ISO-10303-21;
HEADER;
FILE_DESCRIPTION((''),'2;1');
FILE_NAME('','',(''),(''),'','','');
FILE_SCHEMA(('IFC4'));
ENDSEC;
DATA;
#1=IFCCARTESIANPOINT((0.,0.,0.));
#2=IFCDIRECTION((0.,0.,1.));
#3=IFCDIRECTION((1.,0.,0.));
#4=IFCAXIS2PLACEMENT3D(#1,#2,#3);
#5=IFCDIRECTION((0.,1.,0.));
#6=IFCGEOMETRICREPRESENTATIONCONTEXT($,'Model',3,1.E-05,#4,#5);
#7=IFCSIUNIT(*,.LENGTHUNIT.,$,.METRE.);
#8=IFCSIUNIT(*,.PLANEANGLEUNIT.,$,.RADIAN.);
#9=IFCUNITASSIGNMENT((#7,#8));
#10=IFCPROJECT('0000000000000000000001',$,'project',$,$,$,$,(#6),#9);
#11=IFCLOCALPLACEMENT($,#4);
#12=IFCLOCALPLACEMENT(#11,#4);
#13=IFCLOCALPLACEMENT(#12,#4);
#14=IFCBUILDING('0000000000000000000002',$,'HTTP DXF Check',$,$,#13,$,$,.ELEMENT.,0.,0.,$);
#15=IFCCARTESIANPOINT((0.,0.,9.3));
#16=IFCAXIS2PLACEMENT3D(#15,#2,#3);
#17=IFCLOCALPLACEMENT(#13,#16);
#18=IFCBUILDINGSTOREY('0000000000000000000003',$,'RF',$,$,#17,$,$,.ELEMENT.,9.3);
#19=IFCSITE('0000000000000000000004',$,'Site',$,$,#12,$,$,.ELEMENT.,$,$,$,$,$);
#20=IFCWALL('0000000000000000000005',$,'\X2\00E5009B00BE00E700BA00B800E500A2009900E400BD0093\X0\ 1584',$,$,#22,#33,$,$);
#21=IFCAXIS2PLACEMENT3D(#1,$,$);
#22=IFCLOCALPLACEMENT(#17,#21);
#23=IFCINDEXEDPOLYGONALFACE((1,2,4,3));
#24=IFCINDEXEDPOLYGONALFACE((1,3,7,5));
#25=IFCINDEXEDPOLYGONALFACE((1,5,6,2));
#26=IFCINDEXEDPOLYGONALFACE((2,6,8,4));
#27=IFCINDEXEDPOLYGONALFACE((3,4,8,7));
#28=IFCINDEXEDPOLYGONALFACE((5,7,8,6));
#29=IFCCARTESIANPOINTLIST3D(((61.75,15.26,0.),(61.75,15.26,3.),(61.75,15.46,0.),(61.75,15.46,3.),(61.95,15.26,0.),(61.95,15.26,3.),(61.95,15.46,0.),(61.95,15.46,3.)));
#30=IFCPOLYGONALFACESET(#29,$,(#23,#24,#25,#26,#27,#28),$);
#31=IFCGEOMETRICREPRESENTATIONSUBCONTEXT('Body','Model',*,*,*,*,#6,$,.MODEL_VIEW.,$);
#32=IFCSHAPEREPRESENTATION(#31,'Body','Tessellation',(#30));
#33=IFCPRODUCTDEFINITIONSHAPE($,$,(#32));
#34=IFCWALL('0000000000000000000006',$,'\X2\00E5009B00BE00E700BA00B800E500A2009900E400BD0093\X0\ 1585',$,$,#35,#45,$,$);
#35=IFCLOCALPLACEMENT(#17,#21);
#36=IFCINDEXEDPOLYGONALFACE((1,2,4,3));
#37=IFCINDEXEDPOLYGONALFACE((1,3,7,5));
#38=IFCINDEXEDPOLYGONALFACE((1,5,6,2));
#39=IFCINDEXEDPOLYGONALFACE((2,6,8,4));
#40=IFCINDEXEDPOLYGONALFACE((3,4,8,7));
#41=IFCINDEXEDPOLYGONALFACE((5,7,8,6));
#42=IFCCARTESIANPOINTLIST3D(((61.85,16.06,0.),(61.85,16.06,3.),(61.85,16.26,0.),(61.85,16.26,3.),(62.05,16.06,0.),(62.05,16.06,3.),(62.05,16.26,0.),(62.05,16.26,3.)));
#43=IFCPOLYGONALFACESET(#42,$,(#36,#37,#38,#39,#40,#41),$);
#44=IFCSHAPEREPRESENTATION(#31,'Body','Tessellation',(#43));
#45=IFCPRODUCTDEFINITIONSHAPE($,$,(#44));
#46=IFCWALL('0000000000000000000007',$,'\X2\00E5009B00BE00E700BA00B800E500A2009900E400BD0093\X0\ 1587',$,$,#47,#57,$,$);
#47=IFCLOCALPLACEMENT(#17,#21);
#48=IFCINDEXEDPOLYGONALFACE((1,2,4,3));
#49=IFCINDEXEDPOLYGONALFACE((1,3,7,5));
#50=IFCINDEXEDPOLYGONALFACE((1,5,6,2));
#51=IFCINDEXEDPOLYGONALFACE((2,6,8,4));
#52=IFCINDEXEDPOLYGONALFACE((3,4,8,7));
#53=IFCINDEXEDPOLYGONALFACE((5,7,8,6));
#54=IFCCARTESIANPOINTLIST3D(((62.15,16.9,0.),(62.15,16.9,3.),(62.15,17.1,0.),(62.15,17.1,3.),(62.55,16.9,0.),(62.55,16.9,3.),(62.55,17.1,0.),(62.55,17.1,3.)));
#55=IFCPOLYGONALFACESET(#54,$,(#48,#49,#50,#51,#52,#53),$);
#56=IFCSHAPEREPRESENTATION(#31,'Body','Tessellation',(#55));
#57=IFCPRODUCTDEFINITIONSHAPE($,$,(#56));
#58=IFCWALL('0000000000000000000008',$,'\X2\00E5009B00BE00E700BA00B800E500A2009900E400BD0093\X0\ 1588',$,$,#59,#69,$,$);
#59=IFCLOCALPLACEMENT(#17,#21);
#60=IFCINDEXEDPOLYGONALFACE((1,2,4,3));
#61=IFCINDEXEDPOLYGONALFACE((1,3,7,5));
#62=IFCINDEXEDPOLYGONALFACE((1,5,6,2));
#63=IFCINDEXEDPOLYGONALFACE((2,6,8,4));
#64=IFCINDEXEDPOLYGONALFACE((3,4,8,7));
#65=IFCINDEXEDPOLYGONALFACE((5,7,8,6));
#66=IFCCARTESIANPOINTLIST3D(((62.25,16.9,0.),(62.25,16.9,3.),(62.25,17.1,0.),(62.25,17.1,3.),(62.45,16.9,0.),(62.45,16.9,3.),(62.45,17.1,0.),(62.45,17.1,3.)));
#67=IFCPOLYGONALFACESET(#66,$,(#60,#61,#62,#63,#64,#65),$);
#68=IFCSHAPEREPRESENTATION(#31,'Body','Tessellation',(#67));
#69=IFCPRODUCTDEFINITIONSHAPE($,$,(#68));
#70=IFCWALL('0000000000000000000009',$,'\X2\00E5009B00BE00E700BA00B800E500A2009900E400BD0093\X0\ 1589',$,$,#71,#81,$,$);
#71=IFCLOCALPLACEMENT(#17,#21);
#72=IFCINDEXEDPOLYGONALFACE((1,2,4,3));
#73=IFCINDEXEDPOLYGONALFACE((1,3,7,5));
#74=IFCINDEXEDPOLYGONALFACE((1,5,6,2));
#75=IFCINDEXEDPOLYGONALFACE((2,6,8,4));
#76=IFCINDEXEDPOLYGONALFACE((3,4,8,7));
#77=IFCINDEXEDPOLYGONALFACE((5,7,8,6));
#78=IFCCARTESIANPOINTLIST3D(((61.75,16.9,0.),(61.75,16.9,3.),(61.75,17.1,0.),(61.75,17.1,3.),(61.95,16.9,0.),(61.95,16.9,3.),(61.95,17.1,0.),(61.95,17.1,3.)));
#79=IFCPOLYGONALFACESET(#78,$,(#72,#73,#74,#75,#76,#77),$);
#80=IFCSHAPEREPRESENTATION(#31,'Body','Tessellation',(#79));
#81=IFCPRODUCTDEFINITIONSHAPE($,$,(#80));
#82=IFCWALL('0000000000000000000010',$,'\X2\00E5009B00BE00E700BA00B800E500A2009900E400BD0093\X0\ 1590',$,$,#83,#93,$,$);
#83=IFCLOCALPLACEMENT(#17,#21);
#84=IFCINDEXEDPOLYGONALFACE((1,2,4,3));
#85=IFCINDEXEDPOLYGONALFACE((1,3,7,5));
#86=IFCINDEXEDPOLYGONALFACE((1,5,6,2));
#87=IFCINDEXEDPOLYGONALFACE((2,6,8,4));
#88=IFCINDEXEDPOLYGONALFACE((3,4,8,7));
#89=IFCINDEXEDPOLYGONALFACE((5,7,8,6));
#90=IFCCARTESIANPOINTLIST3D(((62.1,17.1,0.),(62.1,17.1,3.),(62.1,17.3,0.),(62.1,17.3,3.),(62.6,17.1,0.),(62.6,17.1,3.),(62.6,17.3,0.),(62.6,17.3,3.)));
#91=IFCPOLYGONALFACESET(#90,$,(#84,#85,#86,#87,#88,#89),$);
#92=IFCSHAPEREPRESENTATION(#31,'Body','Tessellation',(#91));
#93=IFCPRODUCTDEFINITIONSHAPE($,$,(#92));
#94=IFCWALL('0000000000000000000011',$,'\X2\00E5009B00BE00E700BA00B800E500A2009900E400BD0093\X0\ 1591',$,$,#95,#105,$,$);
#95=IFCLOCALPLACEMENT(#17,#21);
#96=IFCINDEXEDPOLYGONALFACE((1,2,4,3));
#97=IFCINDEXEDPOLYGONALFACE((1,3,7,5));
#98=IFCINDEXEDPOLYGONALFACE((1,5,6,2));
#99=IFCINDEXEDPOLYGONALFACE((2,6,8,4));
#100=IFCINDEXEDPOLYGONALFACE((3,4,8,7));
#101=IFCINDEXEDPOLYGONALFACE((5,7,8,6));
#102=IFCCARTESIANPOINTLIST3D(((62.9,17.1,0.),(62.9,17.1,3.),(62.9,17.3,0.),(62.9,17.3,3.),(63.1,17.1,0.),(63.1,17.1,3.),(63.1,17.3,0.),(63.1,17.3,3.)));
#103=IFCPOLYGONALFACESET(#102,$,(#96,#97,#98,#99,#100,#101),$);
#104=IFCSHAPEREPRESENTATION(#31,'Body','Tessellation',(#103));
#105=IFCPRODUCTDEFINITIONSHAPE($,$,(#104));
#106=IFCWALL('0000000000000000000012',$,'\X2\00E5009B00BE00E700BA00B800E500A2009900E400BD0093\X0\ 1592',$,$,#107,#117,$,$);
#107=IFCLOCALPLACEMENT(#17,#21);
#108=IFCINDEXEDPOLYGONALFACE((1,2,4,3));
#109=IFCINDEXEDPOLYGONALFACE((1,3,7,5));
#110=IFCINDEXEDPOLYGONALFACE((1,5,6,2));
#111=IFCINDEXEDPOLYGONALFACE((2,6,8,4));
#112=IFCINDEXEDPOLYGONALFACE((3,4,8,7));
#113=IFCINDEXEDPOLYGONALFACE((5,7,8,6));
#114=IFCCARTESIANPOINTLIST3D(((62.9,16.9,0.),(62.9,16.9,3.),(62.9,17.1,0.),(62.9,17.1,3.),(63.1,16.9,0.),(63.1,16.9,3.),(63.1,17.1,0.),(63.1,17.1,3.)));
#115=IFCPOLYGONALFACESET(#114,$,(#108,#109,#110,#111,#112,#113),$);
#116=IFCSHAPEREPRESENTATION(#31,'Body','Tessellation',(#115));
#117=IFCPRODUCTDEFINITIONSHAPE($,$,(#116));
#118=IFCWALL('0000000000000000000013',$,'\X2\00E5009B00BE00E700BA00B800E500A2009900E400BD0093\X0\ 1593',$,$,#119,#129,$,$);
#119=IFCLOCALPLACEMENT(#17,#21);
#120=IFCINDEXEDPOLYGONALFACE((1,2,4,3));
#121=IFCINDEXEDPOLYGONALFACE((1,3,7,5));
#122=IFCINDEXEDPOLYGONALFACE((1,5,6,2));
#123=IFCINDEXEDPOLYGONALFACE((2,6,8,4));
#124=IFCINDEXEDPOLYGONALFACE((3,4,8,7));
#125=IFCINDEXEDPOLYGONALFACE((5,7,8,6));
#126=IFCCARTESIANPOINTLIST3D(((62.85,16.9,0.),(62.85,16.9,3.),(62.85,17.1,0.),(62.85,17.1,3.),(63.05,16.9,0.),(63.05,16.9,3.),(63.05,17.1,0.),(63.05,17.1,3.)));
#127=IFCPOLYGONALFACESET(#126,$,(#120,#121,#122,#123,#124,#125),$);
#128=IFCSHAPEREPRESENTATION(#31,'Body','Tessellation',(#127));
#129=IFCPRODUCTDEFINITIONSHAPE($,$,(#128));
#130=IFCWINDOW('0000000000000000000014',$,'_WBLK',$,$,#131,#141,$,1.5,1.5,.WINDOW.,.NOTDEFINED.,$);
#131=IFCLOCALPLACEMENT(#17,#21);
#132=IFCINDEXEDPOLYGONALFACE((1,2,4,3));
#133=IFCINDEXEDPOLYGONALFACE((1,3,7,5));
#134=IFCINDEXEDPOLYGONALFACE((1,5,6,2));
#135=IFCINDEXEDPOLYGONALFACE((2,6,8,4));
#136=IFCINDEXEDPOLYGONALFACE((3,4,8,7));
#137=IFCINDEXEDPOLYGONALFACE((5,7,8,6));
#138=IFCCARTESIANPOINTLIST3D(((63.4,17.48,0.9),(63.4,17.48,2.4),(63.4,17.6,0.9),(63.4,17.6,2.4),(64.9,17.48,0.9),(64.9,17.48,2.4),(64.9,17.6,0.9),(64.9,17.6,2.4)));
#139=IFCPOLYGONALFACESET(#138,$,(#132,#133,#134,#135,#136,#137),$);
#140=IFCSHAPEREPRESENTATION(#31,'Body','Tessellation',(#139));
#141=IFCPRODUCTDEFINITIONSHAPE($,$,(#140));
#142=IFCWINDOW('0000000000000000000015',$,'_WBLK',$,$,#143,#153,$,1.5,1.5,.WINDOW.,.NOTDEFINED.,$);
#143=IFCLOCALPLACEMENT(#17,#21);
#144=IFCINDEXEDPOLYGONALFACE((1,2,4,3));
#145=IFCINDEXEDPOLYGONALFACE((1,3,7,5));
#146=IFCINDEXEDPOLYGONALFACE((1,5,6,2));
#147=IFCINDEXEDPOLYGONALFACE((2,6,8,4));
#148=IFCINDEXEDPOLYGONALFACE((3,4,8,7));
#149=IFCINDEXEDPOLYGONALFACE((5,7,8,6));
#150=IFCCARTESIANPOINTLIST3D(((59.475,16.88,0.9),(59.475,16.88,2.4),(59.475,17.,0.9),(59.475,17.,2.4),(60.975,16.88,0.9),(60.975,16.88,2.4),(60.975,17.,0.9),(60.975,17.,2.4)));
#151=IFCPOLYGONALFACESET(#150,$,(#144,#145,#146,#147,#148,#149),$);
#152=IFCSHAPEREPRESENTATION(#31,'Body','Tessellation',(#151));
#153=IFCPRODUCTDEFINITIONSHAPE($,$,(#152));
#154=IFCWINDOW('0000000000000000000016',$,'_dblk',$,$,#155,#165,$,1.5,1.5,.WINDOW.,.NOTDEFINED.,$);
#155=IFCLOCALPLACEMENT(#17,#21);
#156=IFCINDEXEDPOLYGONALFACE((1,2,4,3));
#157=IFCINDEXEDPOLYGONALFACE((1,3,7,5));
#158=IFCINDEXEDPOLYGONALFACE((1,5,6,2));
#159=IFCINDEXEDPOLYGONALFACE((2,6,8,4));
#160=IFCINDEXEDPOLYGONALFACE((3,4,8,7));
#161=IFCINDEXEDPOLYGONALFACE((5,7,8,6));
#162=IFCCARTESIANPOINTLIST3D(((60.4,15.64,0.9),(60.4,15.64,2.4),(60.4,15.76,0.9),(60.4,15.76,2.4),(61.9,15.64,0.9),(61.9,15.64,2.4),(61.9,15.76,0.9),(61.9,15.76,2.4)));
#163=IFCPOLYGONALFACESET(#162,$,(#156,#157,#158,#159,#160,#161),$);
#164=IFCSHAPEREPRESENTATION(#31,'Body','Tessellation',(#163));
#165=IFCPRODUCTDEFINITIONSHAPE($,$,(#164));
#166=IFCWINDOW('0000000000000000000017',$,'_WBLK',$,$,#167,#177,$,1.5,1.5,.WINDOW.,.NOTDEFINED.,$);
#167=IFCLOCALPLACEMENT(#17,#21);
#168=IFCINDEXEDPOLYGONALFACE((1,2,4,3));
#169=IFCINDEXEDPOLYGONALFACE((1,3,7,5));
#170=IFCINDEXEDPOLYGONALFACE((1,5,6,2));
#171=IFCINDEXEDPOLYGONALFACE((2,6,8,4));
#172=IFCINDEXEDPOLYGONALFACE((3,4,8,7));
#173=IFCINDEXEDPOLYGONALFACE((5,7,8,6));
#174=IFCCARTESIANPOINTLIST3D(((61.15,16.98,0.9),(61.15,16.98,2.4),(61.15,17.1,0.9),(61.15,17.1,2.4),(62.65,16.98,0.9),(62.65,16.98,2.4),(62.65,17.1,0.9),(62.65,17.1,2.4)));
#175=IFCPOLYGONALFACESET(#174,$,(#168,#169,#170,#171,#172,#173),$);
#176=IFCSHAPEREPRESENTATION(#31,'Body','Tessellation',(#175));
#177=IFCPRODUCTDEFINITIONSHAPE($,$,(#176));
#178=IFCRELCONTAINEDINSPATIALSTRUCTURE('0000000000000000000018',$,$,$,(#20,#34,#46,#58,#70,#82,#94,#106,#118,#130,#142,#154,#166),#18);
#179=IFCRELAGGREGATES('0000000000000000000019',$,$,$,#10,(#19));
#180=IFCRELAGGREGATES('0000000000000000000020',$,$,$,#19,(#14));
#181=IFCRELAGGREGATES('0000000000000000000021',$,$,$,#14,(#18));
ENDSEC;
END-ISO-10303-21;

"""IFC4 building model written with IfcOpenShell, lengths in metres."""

from ifc_helpers import new_model, si_unit, direction, frame, frame_2d, origin_with_axes, place, context, subcontext, project, spatial, rectangle, extrude, element, save


model = new_model("IFC4")

# Units and contexts
model_context = context("Model", 3, precision=1e-05, world=origin_with_axes(), true_north=direction((0.0, 1.0, 0.0)))
body_context = subcontext(model_context, "Body", "Model", "MODEL_VIEW")
ifc_project = project(units=[si_unit("LENGTHUNIT", "METRE"), si_unit("PLANEANGLEUNIT", "RADIAN")], contexts=[model_context])

# Site, building, storey
placement = place(None, origin_with_axes())
site_placement = place(placement, origin_with_axes())
site = spatial("IfcSite", under=ifc_project, at=site_placement, Name="Site", CompositionType="ELEMENT")
building_placement = place(site_placement, origin_with_axes())
building = spatial("IfcBuilding", under=site, at=building_placement, Name="HTTP DXF Check", CompositionType="ELEMENT", ElevationOfRefHeight=0.0, ElevationOfTerrain=0.0)
storey_placement = place(building_placement, frame((0.0, 0.0, 9.3), z_axis=(0.0, 0.0, 1.0), x_axis=(1.0, 0.0, 0.0)))
storey = spatial("IfcBuildingStorey", under=building, at=storey_placement, Name="RF", CompositionType="ELEMENT", Elevation=9.3)

# Walls
for number, where, z_axis, x_axis, name in (
    (1, (61.85, 15.36, 0.0), (0.0, 0.0, 1.0), (0.0, -1.0, 0.0), "å\u009b¾çº¸å¢\u0099ä½\u0093 1584"),
    (2, (61.95, 16.16, 0.0), (0.0, 0.0, 1.0), (-1.0, 0.0, 0.0), "å\u009b¾çº¸å¢\u0099ä½\u0093 1585"),
):
    element("IfcWall", number, at=place(storey_placement, frame(where, z_axis=z_axis, x_axis=x_axis)), inside=storey, Name=name, context=body_context, shape_type="SweptSolid", body=[
        extrude(rectangle(XDim=0.2, YDim=0.2, at=frame_2d((0.0, 0.0), x_axis=(1.0, 0.0, 0.0))), frame((0.0, 0.0, 0.0), z_axis=(0.0, 0.0, 1.0)), (0.0, 0.0, 1.0), 3.0),
    ])
wall_1_placement = place(storey_placement, frame((62.35, 17.0, 0.0), z_axis=(0.0, 0.0, 1.0), x_axis=(-1.0, 0.0, 0.0)))
element("IfcWall", 3, at=wall_1_placement, inside=storey, Name="å\u009b¾çº¸å¢\u0099ä½\u0093 1587", context=body_context, shape_type="SweptSolid", body=[
    extrude(rectangle(XDim=0.4, YDim=0.2, at=frame_2d((0.0, 0.0), x_axis=(1.0, 0.0, 0.0))), frame((0.0, 0.0, 0.0), z_axis=(0.0, 0.0, 1.0)), (0.0, 0.0, 1.0), 3.0),
])
for number, where, z_axis, x_axis, name in (
    (4, (62.35, 17.0, 0.0), (0.0, 0.0, 1.0), (0.0, 1.0, 0.0), "å\u009b¾çº¸å¢\u0099ä½\u0093 1588"),
    (5, (61.85, 17.0, 0.0), (0.0, 0.0, 1.0), (0.0, 1.0, 0.0), "å\u009b¾çº¸å¢\u0099ä½\u0093 1589"),
):
    element("IfcWall", number, at=place(storey_placement, frame(where, z_axis=z_axis, x_axis=x_axis)), inside=storey, Name=name, context=body_context, shape_type="SweptSolid", body=[
        extrude(rectangle(XDim=0.2, YDim=0.2, at=frame_2d((0.0, 0.0), x_axis=(1.0, 0.0, 0.0))), frame((0.0, 0.0, 0.0), z_axis=(0.0, 0.0, 1.0)), (0.0, 0.0, 1.0), 3.0),
    ])
wall_2_placement = place(storey_placement, frame((62.35, 17.2, 0.0), z_axis=(0.0, 0.0, 1.0), x_axis=(-1.0, 0.0, 0.0)))
element("IfcWall", 6, at=wall_2_placement, inside=storey, Name="å\u009b¾çº¸å¢\u0099ä½\u0093 1590", context=body_context, shape_type="SweptSolid", body=[
    extrude(rectangle(XDim=0.5, YDim=0.2, at=frame_2d((0.0, 0.0), x_axis=(1.0, 0.0, 0.0))), frame((0.0, 0.0, 0.0), z_axis=(0.0, 0.0, 1.0)), (0.0, 0.0, 1.0), 3.0),
])
for number, where, z_axis, x_axis, name in (
    (7, (63.0, 17.2, 0.0), (0.0, 0.0, 1.0), (-1.0, 0.0, 0.0), "å\u009b¾çº¸å¢\u0099ä½\u0093 1591"),
    (8, (63.0, 17.0, 0.0), (0.0, 0.0, 1.0), (-1.0, 0.0, 0.0), "å\u009b¾çº¸å¢\u0099ä½\u0093 1592"),
    (9, (62.95, 17.0, 0.0), (0.0, 0.0, 1.0), (0.0, 1.0, 0.0), "å\u009b¾çº¸å¢\u0099ä½\u0093 1593"),
):
    element("IfcWall", number, at=place(storey_placement, frame(where, z_axis=z_axis, x_axis=x_axis)), inside=storey, Name=name, context=body_context, shape_type="SweptSolid", body=[
        extrude(rectangle(XDim=0.2, YDim=0.2, at=frame_2d((0.0, 0.0), x_axis=(1.0, 0.0, 0.0))), frame((0.0, 0.0, 0.0), z_axis=(0.0, 0.0, 1.0)), (0.0, 0.0, 1.0), 3.0),
    ])

# Windows
for number, where, z_axis, x_axis, name in (
    (10, (64.15, 17.54, 0.9), (0.0, 0.0, 1.0), (1.0, 0.0, 0.0), "_WBLK"),
    (11, (60.225, 16.94, 0.9), (0.0, 0.0, 1.0), (1.0, 0.0, 0.0), "_WBLK"),
    (12, (61.15, 15.7, 0.9), (0.0, 0.0, 1.0), (1.0, 0.0, 0.0), "_dblk"),
    (13, (61.9, 17.04, 0.9), (0.0, 0.0, 1.0), (1.0, 0.0, 0.0), "_WBLK"),
):
    element("IfcWindow", number, at=place(storey_placement, frame(where, z_axis=z_axis, x_axis=x_axis)), inside=storey, Name=name, OverallHeight=1.5, OverallWidth=1.5, PartitioningType="NOTDEFINED", PredefinedType="WINDOW", context=body_context, shape_type="SweptSolid", body=[
        extrude(rectangle(XDim=1.5, YDim=0.12, at=frame_2d((0.0, 0.0), x_axis=(1.0, 0.0, 0.0))), frame((0.0, 0.0, 0.0), z_axis=(0.0, 0.0, 1.0)), (0.0, 0.0, 1.0), 1.5),
    ])

save(model, "model.ifc")
